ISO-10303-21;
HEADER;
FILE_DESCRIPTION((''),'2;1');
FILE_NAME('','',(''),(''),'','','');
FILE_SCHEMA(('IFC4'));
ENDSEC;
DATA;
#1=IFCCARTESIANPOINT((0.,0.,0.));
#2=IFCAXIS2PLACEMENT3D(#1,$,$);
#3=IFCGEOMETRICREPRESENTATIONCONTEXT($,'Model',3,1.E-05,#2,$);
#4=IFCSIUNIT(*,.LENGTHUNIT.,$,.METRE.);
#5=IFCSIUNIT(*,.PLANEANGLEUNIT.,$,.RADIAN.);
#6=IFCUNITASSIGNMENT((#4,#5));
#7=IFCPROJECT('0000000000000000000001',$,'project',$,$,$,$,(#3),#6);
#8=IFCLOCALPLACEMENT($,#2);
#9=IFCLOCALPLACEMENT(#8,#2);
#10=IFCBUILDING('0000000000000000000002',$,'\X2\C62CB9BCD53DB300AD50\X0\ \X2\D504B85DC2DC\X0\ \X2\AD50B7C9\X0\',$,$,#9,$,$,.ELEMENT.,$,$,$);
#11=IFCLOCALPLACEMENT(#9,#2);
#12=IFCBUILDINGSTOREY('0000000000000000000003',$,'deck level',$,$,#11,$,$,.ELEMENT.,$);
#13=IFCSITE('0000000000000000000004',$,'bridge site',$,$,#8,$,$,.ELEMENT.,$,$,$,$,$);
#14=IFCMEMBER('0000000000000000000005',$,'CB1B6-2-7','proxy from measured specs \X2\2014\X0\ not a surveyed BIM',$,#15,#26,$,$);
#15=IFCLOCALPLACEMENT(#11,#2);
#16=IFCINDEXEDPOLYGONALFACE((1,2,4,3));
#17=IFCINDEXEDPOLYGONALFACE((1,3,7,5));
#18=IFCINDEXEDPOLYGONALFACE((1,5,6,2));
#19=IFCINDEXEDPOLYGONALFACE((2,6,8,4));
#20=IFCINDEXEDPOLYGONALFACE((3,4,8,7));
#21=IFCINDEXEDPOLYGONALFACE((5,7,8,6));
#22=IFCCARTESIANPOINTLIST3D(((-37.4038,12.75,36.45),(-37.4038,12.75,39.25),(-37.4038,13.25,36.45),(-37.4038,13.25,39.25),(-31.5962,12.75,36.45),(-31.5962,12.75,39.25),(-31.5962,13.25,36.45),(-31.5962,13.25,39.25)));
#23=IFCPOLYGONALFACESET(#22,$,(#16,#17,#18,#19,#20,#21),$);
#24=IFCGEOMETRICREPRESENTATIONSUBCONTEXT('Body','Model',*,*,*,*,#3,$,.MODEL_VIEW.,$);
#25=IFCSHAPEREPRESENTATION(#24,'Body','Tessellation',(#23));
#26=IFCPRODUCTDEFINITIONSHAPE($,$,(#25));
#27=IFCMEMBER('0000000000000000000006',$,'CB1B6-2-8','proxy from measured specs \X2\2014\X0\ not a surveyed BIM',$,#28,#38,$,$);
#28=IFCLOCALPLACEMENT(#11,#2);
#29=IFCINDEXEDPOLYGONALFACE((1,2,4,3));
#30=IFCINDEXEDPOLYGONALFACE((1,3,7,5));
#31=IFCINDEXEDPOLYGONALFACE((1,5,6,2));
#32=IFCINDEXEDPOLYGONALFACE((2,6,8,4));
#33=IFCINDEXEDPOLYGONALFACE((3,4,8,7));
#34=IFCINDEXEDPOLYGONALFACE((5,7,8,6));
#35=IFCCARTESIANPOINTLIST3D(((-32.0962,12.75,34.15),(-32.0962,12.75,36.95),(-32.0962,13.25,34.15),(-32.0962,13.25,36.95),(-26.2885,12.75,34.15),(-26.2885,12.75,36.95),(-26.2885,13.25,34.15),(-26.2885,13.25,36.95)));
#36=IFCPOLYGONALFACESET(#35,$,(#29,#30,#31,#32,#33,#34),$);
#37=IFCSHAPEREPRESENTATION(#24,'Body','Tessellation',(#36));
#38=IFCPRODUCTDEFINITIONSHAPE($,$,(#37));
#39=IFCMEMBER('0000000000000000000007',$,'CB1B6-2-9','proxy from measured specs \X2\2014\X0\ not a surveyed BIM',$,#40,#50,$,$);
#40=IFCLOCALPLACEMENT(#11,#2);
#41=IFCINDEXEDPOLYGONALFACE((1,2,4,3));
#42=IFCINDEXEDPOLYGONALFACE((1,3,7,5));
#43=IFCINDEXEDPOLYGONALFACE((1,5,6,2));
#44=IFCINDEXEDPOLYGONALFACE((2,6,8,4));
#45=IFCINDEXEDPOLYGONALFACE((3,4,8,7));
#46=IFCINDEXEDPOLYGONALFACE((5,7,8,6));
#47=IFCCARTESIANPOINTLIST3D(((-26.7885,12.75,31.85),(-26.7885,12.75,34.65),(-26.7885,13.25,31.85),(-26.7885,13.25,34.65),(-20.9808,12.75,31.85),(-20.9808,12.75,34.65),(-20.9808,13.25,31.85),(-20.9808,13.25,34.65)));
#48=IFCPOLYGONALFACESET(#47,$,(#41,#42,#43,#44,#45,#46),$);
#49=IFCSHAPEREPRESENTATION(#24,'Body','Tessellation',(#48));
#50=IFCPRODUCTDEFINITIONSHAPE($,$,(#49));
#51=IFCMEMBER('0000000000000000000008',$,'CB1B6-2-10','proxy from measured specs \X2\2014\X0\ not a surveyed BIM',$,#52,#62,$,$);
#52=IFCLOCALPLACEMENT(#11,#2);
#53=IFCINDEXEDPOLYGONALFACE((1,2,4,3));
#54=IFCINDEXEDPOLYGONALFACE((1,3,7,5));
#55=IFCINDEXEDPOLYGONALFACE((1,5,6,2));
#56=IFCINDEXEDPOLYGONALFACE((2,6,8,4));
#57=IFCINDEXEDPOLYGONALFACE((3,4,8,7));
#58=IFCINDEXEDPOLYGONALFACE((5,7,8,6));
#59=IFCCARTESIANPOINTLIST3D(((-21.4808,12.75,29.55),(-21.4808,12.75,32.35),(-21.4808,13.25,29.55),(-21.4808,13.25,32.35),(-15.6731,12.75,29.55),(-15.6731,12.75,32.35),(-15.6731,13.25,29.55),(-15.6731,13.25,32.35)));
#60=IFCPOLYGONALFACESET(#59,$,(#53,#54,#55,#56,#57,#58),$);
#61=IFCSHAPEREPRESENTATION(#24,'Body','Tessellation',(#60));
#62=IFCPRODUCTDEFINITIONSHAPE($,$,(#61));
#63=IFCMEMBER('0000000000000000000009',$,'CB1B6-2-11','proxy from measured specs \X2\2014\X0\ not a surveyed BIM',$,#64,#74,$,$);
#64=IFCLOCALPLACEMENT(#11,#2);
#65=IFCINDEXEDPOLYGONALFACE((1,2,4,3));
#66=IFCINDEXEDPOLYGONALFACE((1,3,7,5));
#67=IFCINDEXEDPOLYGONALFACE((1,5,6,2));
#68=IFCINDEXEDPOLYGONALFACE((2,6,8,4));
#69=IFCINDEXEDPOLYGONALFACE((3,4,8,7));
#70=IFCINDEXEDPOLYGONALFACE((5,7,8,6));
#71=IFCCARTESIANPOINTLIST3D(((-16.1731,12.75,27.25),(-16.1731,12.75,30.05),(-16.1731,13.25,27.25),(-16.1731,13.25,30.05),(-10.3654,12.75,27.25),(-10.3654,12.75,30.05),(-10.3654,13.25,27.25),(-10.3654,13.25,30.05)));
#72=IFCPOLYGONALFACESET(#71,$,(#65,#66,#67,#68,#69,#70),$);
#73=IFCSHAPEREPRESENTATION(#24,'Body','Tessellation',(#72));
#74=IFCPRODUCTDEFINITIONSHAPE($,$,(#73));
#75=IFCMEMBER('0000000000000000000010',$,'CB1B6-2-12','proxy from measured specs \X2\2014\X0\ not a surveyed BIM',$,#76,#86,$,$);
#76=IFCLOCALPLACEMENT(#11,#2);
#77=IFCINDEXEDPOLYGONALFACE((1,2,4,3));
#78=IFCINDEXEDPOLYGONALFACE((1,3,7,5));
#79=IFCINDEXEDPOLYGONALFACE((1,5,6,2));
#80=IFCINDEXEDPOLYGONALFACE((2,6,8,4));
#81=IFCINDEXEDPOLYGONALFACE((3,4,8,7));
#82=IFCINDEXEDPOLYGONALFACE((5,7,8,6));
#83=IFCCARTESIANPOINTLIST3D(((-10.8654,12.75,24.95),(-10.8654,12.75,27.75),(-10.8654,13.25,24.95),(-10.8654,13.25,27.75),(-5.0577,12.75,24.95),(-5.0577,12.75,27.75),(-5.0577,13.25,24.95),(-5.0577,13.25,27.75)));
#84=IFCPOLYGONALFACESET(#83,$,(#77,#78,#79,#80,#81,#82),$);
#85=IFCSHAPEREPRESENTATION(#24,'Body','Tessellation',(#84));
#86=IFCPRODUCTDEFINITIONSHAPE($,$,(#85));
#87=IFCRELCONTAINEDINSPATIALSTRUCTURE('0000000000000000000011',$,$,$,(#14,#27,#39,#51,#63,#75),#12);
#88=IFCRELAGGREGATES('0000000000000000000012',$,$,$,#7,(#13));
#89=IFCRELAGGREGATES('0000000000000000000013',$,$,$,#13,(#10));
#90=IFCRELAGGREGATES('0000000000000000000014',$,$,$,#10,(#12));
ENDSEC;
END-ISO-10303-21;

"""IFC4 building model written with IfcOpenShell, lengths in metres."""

from ifc_helpers import new_model, si_unit, frame, origin, origin_2d, place, context, subcontext, project, spatial, rectangle, extrude, element, save


model = new_model("IFC4")

# Units and contexts
model_context = context("Model", 3, precision=1e-05, world=origin())
body_context = subcontext(model_context, "Body", "Model", "MODEL_VIEW")
ifc_project = project(units=[si_unit("LENGTHUNIT", "METRE"), si_unit("PLANEANGLEUNIT", "RADIAN")], contexts=[model_context])

# Site, building, storey
site_placement = place(None, origin())
site = spatial("IfcSite", under=ifc_project, at=site_placement, Name="bridge site", CompositionType="ELEMENT")
building_placement = place(site_placement, origin())
building = spatial("IfcBuilding", under=site, at=building_placement, Name="올림픽대교 프록시 교량", CompositionType="ELEMENT")
storey_placement = place(building_placement, origin())
storey = spatial("IfcBuildingStorey", under=building, at=storey_placement, Name="deck level", CompositionType="ELEMENT")

# Members
member_1_placement = place(storey_placement, frame((-34.5, 13.0, 36.45)))
element("IfcMember", 1, at=member_1_placement, inside=storey, Name="CB1B6-2-7", Description="proxy from measured specs — not a surveyed BIM", context=body_context, shape_type="SweptSolid", body=[
    extrude(rectangle(XDim=5.8077, YDim=0.5, at=origin_2d()), origin(), (0.0, 0.0, 1.0), 2.8),
])
member_2_placement = place(storey_placement, frame((-29.1923, 13.0, 34.15)))
element("IfcMember", 2, at=member_2_placement, inside=storey, Name="CB1B6-2-8", Description="proxy from measured specs — not a surveyed BIM", context=body_context, shape_type="SweptSolid", body=[
    extrude(rectangle(XDim=5.8077, YDim=0.5, at=origin_2d()), origin(), (0.0, 0.0, 1.0), 2.8),
])
member_3_placement = place(storey_placement, frame((-23.8846, 13.0, 31.85)))
element("IfcMember", 3, at=member_3_placement, inside=storey, Name="CB1B6-2-9", Description="proxy from measured specs — not a surveyed BIM", context=body_context, shape_type="SweptSolid", body=[
    extrude(rectangle(XDim=5.8077, YDim=0.5, at=origin_2d()), origin(), (0.0, 0.0, 1.0), 2.8),
])
member_4_placement = place(storey_placement, frame((-18.5769, 13.0, 29.55)))
element("IfcMember", 4, at=member_4_placement, inside=storey, Name="CB1B6-2-10", Description="proxy from measured specs — not a surveyed BIM", context=body_context, shape_type="SweptSolid", body=[
    extrude(rectangle(XDim=5.8077, YDim=0.5, at=origin_2d()), origin(), (0.0, 0.0, 1.0), 2.8),
])
member_5_placement = place(storey_placement, frame((-13.2692, 13.0, 27.25)))
element("IfcMember", 5, at=member_5_placement, inside=storey, Name="CB1B6-2-11", Description="proxy from measured specs — not a surveyed BIM", context=body_context, shape_type="SweptSolid", body=[
    extrude(rectangle(XDim=5.8077, YDim=0.5, at=origin_2d()), origin(), (0.0, 0.0, 1.0), 2.8),
])
member_6_placement = place(storey_placement, frame((-7.9615, 13.0, 24.95)))
element("IfcMember", 6, at=member_6_placement, inside=storey, Name="CB1B6-2-12", Description="proxy from measured specs — not a surveyed BIM", context=body_context, shape_type="SweptSolid", body=[
    extrude(rectangle(XDim=5.8077, YDim=0.5, at=origin_2d()), origin(), (0.0, 0.0, 1.0), 2.8),
])

save(model, "model.ifc")
